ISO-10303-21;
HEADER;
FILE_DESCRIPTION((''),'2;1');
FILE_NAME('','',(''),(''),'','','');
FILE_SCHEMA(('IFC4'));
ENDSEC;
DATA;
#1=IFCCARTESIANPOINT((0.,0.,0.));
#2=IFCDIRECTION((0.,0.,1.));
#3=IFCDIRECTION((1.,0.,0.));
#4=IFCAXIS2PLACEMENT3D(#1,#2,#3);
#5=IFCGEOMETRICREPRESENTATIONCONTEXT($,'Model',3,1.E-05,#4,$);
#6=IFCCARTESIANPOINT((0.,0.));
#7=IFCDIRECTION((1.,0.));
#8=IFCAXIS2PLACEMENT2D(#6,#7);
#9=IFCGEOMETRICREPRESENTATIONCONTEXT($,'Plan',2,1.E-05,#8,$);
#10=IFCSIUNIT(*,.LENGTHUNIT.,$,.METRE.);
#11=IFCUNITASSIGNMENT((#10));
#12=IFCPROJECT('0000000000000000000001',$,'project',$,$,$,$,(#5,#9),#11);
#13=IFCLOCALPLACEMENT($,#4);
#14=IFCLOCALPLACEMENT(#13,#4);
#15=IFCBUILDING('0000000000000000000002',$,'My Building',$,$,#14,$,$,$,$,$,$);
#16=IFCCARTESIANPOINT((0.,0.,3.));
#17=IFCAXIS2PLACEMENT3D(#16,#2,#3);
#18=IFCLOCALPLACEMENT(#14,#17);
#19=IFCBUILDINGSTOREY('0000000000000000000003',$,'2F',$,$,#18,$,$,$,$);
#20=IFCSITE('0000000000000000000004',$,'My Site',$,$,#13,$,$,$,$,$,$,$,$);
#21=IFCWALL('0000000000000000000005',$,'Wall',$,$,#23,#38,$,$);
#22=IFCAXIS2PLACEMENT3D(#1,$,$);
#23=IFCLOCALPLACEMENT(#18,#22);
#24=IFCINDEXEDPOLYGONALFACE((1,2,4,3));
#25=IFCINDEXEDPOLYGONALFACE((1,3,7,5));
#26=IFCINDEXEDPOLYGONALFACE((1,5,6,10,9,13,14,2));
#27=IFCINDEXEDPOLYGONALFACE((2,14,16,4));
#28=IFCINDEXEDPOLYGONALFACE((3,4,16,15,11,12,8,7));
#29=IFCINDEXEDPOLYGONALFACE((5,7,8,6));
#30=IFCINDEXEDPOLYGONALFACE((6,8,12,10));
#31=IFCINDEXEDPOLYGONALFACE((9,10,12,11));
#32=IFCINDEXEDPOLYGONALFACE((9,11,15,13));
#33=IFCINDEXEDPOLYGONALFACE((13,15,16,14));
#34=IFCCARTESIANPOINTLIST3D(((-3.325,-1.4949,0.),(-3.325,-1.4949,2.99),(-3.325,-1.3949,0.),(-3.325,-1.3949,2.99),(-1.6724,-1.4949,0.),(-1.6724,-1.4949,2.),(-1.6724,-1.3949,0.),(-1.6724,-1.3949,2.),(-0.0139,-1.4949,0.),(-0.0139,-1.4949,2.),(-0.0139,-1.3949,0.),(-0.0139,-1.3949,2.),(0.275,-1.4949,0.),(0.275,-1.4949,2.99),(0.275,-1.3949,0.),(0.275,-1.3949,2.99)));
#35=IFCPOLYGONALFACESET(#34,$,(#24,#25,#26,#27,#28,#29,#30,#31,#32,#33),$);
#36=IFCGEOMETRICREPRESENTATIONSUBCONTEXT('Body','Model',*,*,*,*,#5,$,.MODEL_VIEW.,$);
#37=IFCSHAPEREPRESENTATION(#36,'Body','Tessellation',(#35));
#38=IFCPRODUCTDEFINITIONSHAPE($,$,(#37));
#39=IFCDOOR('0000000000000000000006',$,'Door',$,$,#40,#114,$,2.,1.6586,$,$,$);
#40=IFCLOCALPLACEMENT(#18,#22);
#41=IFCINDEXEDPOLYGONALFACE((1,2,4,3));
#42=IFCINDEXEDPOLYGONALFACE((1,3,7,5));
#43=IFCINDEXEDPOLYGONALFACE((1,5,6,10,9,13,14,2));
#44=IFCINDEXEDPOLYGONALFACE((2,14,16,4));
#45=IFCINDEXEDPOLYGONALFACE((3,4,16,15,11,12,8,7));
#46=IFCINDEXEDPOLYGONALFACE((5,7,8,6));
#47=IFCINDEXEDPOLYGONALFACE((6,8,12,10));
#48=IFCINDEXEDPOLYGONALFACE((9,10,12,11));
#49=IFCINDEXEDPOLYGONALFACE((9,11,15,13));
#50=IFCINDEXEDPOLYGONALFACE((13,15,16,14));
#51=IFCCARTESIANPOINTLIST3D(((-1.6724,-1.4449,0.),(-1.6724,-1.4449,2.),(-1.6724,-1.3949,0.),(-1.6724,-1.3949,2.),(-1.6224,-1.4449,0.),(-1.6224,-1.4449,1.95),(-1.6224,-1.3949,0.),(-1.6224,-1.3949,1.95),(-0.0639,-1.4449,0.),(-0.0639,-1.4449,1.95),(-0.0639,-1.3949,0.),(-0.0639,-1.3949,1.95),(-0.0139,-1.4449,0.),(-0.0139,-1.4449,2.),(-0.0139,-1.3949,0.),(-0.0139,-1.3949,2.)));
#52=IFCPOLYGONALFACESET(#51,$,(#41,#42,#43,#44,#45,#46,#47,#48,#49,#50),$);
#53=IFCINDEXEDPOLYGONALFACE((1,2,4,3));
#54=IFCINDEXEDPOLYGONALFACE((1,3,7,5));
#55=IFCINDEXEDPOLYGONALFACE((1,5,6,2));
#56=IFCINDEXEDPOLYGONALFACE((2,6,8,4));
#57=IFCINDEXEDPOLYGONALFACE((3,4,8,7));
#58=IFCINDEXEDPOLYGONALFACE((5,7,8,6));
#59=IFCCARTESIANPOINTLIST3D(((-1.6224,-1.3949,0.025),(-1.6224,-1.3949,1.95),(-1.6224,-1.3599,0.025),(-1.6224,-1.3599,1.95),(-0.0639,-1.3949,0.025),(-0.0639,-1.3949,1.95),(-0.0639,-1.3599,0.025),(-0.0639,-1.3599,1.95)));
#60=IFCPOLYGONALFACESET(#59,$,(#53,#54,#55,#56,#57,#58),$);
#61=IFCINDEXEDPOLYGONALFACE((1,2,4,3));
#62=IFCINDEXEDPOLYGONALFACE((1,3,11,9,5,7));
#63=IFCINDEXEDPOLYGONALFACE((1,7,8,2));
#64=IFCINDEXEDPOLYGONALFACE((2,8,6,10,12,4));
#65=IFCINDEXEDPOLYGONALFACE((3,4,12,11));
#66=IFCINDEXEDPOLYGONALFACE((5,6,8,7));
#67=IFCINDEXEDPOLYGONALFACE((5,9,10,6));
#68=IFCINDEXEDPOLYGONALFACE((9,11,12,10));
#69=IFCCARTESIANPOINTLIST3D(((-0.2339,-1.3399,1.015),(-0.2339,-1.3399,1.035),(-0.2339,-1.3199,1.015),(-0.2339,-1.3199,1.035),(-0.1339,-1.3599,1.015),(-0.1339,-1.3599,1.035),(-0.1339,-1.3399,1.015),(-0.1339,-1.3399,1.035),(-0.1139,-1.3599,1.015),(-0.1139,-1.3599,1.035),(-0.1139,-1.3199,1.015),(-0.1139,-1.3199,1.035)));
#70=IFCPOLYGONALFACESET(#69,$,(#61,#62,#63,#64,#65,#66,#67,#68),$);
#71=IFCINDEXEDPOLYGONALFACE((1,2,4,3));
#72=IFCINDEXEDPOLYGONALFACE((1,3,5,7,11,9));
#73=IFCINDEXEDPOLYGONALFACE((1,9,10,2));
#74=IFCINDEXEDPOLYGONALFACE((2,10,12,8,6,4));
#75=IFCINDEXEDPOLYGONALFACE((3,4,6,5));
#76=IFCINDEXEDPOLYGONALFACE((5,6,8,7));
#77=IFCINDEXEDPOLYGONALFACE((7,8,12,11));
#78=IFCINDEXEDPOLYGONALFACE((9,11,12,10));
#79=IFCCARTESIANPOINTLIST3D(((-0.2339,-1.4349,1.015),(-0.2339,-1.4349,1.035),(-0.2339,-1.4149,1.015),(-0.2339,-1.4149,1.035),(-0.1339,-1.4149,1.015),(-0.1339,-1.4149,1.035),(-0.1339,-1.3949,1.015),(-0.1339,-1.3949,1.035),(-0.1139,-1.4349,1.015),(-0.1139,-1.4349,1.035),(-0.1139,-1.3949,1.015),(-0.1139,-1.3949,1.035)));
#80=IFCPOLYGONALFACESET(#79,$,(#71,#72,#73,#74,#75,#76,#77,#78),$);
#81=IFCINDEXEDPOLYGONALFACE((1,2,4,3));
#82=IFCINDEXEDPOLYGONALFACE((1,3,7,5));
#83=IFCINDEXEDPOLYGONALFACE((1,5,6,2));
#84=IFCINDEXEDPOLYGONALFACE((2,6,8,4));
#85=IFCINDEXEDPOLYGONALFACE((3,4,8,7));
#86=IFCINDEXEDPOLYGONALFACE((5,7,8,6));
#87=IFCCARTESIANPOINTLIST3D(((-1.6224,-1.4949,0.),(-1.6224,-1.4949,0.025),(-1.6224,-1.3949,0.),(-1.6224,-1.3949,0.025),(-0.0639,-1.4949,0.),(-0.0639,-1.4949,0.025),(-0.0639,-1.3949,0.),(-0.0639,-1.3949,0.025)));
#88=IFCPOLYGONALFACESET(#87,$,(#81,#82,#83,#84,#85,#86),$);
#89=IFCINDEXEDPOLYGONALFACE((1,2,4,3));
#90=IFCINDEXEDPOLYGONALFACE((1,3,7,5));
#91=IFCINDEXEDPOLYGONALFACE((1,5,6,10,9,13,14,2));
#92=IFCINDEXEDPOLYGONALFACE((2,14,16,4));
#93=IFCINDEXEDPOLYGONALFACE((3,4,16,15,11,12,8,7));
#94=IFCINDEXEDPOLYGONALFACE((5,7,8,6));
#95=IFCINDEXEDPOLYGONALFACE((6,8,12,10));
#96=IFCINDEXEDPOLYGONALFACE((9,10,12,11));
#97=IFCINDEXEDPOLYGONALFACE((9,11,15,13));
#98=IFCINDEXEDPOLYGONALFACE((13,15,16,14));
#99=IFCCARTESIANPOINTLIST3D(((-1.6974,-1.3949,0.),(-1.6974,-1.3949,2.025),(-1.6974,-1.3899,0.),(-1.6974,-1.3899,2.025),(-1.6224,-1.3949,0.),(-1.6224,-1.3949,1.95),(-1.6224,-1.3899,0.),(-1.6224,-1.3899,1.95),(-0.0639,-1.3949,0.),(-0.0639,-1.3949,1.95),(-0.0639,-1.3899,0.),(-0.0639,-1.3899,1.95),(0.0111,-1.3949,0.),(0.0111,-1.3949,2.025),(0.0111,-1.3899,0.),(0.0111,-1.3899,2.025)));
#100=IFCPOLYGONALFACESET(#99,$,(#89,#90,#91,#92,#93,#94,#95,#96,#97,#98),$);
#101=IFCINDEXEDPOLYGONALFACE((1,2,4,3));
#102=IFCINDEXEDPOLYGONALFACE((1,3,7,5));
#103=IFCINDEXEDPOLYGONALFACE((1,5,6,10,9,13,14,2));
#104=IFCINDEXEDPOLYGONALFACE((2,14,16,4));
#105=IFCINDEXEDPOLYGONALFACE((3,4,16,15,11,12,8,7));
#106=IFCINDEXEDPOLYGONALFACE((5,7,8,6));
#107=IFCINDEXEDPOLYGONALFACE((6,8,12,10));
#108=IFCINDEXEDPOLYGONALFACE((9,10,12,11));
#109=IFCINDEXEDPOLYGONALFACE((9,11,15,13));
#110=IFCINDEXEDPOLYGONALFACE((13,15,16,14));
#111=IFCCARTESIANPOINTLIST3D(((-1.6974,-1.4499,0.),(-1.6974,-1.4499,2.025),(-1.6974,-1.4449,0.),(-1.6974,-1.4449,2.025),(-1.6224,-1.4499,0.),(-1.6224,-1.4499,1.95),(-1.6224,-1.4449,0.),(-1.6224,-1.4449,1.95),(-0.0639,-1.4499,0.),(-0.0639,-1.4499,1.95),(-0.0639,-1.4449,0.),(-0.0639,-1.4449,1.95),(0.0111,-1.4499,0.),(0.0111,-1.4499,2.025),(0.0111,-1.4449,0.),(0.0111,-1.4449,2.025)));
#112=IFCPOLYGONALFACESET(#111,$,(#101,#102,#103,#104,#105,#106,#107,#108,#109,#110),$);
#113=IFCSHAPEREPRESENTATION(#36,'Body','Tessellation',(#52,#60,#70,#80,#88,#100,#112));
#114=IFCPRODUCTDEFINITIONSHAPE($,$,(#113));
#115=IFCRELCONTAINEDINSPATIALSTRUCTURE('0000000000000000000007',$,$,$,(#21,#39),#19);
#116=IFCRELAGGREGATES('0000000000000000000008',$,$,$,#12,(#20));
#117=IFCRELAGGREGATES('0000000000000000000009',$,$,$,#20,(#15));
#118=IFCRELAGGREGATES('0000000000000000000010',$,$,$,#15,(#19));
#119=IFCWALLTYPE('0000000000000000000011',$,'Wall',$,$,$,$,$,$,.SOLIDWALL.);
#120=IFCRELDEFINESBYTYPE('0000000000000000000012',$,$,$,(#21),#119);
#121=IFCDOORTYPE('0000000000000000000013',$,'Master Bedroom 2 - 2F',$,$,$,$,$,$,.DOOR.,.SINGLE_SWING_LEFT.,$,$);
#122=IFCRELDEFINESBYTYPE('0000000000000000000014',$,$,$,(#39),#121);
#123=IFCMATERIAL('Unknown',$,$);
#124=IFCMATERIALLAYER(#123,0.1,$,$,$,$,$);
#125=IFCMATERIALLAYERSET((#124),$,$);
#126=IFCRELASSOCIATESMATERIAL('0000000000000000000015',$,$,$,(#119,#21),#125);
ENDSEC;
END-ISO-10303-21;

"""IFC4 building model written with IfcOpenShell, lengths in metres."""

from ifc_helpers import new_model, entity, si_unit, frame, origin_with_axes, origin_2d_with_axis, place, context, subcontext, project, spatial, line, indexed_curve, outline, extrude, shape, source, transform, mapped, material, layer, layer_set, layer_usage, type_object, type_shapes, element, fill, save


model = new_model("IFC4")

# Units and contexts
model_context = context("Model", 3, precision=1e-05, world=origin_with_axes())
plan_context = context("Plan", 2, precision=1e-05, world=origin_2d_with_axis())
body_context_1 = subcontext(model_context, "Body", "Model", "MODEL_VIEW")
body_context_2 = subcontext(plan_context, "Body", "Plan", "PLAN_VIEW")
ifc_project = project(units=[si_unit("LENGTHUNIT", "METRE")], contexts=[model_context, plan_context])

# Site, building, storey
site_placement = place(None, origin_with_axes())
site = spatial("IfcSite", under=ifc_project, at=site_placement, Name="My Site")
building_placement = place(site_placement, origin_with_axes())
building = spatial("IfcBuilding", under=site, at=building_placement, Name="My Building")
storey_placement = place(building_placement, frame((0.0, 0.0, 3.0), z_axis=(0.0, 0.0, 1.0), x_axis=(1.0, 0.0, 0.0)))
storey = spatial("IfcBuildingStorey", under=building, at=storey_placement, Name="2F")

# Shared definitions
ifc_material = material(Name="Unknown")

# Shared definitions
ifc_layer_1 = layer(ifc_material, 0.1)
ifc_layer_set_1 = layer_set([ifc_layer_1])
wall_type = type_object("IfcWallType", Name="Wall", PredefinedType="SOLIDWALL", material=ifc_layer_set_1)

# Wall, opening, door
ifc_layer_usage_1 = layer_usage(ifc_layer_set_1, "AXIS2", "POSITIVE", 0.0)
wall_1_placement = place(storey_placement, frame((-3.325, -1.4949, 0.0), z_axis=(0.0, 0.0, 1.0), x_axis=(1.0, 0.0, 0.0)))
wall_1 = element("IfcWall", 1, at=wall_1_placement, inside=storey, type_object=wall_type, material=ifc_layer_usage_1, Name="Wall", context=body_context_1, shape_type="SweptSolid", body=[
    extrude(outline(indexed_curve([(0.0, 0.0), (0.0, 0.1), (3.6, 0.1), (3.6, 0.0)], segments=[line(1, 2, 3, 4, 1)])), origin_with_axes(), (0.0, 0.0, 1.0), 2.99),
])
shared_shape_1 = source(origin_with_axes(), body_context_1, "Body", "SweptSolid", [
    extrude(outline(indexed_curve([(0.0, 0.0), (1.6586, 0.0), (1.6586, 2.0), (0.0, 2.0)], segments=[line(1, 2, 3, 4, 1)])), frame((0.0, -0.6, 0.0), z_axis=(0.0, -1.0, 0.0), x_axis=(1.0, 0.0, 0.0)), (0.0, 0.0, -1.0), 1.2),
])
opening_1_placement = place(wall_1_placement, frame((3.3111, 0.1, 0.0), z_axis=(0.0, 0.0, 1.0), x_axis=(-1.0, 0.0, 0.0)))
opening_1 = element("IfcOpeningElement", 2, at=opening_1_placement, cuts=wall_1, PredefinedType="OPENING", context=body_context_1, shape_type="MappedRepresentation", body=[
    mapped(shared_shape_1, transform((0.0, 0.0, 0.0), x_axis=(1.0, 0.0, 0.0), y_axis=(0.0, 1.0, 0.0), z_axis=(0.0, 0.0, 1.0), scale=1.0)),
])
door_type_1 = type_object("IfcDoorType", Name="Master Bedroom 2 - 2F", OperationType="SINGLE_SWING_LEFT", PredefinedType="DOOR")
shared_shape_2 = source(origin_with_axes(), body_context_1, "Body", "SweptSolid", [
    extrude(outline(indexed_curve([(0.0, 0.0), (0.0, 2.0), (1.6586, 2.0), (1.6586, 0.0), (1.6086, 0.0), (1.6086, 1.95), (0.05, 1.95), (0.05, 0.0)], segments=[line(1, 2, 3, 4, 5, 6, 7, 8, 1)])), frame((0.0, 0.0, 0.0), z_axis=(0.0, -1.0, 0.0), x_axis=(1.0, 0.0, 0.0)), (0.0, 0.0, -1.0), 0.05),
    extrude(outline(indexed_curve([(0.0, 0.0), (1.5586, 0.0), (1.5586, 0.035), (0.0, 0.035)], segments=[line(1, 2, 3, 4, 1)])), frame((0.05, -0.035, 0.025), z_axis=(0.0, 0.0, 1.0), x_axis=(1.0, 0.0, 0.0)), (0.0, 0.0, 1.0), 1.925),
    extrude(outline(indexed_curve([(0.0, 0.0), (0.0, -0.04), (0.12, -0.04), (0.12, -0.02), (0.02, -0.02), (0.02, 0.0)], segments=[line(1, 2, 3, 4, 5, 6, 1)])), frame((0.1, -0.035, 1.015), z_axis=(0.0, 0.0, 1.0), x_axis=(1.0, 0.0, 0.0)), (0.0, 0.0, 1.0), 0.02),
    extrude(outline(indexed_curve([(0.0, 0.0), (0.0, 0.04), (0.12, 0.04), (0.12, 0.02), (0.02, 0.02), (0.02, 0.0)], segments=[line(1, 2, 3, 4, 5, 6, 1)])), frame((0.1, 0.0, 1.015), z_axis=(0.0, 0.0, 1.0), x_axis=(1.0, 0.0, 0.0)), (0.0, 0.0, 1.0), 0.02),
    extrude(outline(indexed_curve([(0.0, 0.0), (1.5586, 0.0), (1.5586, 0.1), (0.0, 0.1)], segments=[line(1, 2, 3, 4, 1)])), frame((0.05, 0.0, 0.0), z_axis=(0.0, 0.0, 1.0), x_axis=(1.0, 0.0, 0.0)), (0.0, 0.0, 1.0), 0.025),
    extrude(outline(indexed_curve([(0.0, 0.0), (0.0, 2.025), (1.7086, 2.025), (1.7086, 0.0), (1.6336, 0.0), (1.6336, 1.95), (0.075, 1.95), (0.075, 0.0)], segments=[line(1, 2, 3, 4, 5, 6, 7, 8, 1)])), frame((-0.025, -0.005, 0.0), z_axis=(0.0, -1.0, 0.0), x_axis=(1.0, 0.0, 0.0)), (0.0, 0.0, -1.0), 0.005),
    extrude(outline(indexed_curve([(0.0, 0.0), (0.0, 2.025), (1.7086, 2.025), (1.7086, 0.0), (1.6336, 0.0), (1.6336, 1.95), (0.075, 1.95), (0.075, 0.0)], segments=[line(1, 2, 3, 4, 5, 6, 7, 8, 1)])), frame((-0.025, 0.05, 0.0), z_axis=(0.0, -1.0, 0.0), x_axis=(1.0, 0.0, 0.0)), (0.0, 0.0, -1.0), 0.005),
])
shared_shape_3 = source(origin_with_axes(), body_context_2, "Body", "Curve2D", [
    entity("IfcIndexedPolyCurve", entity("IfcCartesianPointList2D", [[0.0, 0.0], [0.05, 0.0], [0.05, 0.05], [0.0, 0.05]]), [entity("IfcLineIndex", [1, 2, 3, 4, 1])]),
    entity("IfcIndexedPolyCurve", entity("IfcCartesianPointList2D", [[1.6586, 0.0], [1.6086, 0.0], [1.6086, 0.05], [1.6586, 0.05]]), [entity("IfcLineIndex", [1, 2, 3, 4, 1])]),
    entity("IfcIndexedPolyCurve", entity("IfcCartesianPointList2D", [[2.3879, -0.035], [0.8293, -0.035], [0.8293, 0.0], [2.3879, 0.0]]), [entity("IfcLineIndex", [1, 2, 3, 4, 1])]),
])
type_shapes(door_type_1, [shared_shape_2, shared_shape_3])
door_1_placement = place(opening_1_placement, frame((0.0, 0.0, 0.0), z_axis=(0.0, 0.0, 1.0), x_axis=(1.0, 0.0, 0.0)))
door_1 = element("IfcDoor", 3, at=door_1_placement, inside=storey, type_object=door_type_1, Name="Door", OverallHeight=2.0, OverallWidth=1.6586, shapes=[
    shape(body_context_1, "Body", "MappedRepresentation", [mapped(shared_shape_2, transform((0.0, 0.0, 0.0), x_axis=(1.0, 0.0, 0.0), y_axis=(0.0, 1.0, 0.0), z_axis=(0.0, 0.0, 1.0), scale=1.0))]),
    shape(body_context_2, "Body", "MappedRepresentation", [mapped(shared_shape_3, transform((0.0, 0.0, 0.0), x_axis=(1.0, 0.0, 0.0), y_axis=(0.0, 1.0, 0.0), z_axis=(0.0, 0.0, 1.0), scale=1.0))]),
])
fill(opening_1, door_1)

save(model, "model.ifc")
